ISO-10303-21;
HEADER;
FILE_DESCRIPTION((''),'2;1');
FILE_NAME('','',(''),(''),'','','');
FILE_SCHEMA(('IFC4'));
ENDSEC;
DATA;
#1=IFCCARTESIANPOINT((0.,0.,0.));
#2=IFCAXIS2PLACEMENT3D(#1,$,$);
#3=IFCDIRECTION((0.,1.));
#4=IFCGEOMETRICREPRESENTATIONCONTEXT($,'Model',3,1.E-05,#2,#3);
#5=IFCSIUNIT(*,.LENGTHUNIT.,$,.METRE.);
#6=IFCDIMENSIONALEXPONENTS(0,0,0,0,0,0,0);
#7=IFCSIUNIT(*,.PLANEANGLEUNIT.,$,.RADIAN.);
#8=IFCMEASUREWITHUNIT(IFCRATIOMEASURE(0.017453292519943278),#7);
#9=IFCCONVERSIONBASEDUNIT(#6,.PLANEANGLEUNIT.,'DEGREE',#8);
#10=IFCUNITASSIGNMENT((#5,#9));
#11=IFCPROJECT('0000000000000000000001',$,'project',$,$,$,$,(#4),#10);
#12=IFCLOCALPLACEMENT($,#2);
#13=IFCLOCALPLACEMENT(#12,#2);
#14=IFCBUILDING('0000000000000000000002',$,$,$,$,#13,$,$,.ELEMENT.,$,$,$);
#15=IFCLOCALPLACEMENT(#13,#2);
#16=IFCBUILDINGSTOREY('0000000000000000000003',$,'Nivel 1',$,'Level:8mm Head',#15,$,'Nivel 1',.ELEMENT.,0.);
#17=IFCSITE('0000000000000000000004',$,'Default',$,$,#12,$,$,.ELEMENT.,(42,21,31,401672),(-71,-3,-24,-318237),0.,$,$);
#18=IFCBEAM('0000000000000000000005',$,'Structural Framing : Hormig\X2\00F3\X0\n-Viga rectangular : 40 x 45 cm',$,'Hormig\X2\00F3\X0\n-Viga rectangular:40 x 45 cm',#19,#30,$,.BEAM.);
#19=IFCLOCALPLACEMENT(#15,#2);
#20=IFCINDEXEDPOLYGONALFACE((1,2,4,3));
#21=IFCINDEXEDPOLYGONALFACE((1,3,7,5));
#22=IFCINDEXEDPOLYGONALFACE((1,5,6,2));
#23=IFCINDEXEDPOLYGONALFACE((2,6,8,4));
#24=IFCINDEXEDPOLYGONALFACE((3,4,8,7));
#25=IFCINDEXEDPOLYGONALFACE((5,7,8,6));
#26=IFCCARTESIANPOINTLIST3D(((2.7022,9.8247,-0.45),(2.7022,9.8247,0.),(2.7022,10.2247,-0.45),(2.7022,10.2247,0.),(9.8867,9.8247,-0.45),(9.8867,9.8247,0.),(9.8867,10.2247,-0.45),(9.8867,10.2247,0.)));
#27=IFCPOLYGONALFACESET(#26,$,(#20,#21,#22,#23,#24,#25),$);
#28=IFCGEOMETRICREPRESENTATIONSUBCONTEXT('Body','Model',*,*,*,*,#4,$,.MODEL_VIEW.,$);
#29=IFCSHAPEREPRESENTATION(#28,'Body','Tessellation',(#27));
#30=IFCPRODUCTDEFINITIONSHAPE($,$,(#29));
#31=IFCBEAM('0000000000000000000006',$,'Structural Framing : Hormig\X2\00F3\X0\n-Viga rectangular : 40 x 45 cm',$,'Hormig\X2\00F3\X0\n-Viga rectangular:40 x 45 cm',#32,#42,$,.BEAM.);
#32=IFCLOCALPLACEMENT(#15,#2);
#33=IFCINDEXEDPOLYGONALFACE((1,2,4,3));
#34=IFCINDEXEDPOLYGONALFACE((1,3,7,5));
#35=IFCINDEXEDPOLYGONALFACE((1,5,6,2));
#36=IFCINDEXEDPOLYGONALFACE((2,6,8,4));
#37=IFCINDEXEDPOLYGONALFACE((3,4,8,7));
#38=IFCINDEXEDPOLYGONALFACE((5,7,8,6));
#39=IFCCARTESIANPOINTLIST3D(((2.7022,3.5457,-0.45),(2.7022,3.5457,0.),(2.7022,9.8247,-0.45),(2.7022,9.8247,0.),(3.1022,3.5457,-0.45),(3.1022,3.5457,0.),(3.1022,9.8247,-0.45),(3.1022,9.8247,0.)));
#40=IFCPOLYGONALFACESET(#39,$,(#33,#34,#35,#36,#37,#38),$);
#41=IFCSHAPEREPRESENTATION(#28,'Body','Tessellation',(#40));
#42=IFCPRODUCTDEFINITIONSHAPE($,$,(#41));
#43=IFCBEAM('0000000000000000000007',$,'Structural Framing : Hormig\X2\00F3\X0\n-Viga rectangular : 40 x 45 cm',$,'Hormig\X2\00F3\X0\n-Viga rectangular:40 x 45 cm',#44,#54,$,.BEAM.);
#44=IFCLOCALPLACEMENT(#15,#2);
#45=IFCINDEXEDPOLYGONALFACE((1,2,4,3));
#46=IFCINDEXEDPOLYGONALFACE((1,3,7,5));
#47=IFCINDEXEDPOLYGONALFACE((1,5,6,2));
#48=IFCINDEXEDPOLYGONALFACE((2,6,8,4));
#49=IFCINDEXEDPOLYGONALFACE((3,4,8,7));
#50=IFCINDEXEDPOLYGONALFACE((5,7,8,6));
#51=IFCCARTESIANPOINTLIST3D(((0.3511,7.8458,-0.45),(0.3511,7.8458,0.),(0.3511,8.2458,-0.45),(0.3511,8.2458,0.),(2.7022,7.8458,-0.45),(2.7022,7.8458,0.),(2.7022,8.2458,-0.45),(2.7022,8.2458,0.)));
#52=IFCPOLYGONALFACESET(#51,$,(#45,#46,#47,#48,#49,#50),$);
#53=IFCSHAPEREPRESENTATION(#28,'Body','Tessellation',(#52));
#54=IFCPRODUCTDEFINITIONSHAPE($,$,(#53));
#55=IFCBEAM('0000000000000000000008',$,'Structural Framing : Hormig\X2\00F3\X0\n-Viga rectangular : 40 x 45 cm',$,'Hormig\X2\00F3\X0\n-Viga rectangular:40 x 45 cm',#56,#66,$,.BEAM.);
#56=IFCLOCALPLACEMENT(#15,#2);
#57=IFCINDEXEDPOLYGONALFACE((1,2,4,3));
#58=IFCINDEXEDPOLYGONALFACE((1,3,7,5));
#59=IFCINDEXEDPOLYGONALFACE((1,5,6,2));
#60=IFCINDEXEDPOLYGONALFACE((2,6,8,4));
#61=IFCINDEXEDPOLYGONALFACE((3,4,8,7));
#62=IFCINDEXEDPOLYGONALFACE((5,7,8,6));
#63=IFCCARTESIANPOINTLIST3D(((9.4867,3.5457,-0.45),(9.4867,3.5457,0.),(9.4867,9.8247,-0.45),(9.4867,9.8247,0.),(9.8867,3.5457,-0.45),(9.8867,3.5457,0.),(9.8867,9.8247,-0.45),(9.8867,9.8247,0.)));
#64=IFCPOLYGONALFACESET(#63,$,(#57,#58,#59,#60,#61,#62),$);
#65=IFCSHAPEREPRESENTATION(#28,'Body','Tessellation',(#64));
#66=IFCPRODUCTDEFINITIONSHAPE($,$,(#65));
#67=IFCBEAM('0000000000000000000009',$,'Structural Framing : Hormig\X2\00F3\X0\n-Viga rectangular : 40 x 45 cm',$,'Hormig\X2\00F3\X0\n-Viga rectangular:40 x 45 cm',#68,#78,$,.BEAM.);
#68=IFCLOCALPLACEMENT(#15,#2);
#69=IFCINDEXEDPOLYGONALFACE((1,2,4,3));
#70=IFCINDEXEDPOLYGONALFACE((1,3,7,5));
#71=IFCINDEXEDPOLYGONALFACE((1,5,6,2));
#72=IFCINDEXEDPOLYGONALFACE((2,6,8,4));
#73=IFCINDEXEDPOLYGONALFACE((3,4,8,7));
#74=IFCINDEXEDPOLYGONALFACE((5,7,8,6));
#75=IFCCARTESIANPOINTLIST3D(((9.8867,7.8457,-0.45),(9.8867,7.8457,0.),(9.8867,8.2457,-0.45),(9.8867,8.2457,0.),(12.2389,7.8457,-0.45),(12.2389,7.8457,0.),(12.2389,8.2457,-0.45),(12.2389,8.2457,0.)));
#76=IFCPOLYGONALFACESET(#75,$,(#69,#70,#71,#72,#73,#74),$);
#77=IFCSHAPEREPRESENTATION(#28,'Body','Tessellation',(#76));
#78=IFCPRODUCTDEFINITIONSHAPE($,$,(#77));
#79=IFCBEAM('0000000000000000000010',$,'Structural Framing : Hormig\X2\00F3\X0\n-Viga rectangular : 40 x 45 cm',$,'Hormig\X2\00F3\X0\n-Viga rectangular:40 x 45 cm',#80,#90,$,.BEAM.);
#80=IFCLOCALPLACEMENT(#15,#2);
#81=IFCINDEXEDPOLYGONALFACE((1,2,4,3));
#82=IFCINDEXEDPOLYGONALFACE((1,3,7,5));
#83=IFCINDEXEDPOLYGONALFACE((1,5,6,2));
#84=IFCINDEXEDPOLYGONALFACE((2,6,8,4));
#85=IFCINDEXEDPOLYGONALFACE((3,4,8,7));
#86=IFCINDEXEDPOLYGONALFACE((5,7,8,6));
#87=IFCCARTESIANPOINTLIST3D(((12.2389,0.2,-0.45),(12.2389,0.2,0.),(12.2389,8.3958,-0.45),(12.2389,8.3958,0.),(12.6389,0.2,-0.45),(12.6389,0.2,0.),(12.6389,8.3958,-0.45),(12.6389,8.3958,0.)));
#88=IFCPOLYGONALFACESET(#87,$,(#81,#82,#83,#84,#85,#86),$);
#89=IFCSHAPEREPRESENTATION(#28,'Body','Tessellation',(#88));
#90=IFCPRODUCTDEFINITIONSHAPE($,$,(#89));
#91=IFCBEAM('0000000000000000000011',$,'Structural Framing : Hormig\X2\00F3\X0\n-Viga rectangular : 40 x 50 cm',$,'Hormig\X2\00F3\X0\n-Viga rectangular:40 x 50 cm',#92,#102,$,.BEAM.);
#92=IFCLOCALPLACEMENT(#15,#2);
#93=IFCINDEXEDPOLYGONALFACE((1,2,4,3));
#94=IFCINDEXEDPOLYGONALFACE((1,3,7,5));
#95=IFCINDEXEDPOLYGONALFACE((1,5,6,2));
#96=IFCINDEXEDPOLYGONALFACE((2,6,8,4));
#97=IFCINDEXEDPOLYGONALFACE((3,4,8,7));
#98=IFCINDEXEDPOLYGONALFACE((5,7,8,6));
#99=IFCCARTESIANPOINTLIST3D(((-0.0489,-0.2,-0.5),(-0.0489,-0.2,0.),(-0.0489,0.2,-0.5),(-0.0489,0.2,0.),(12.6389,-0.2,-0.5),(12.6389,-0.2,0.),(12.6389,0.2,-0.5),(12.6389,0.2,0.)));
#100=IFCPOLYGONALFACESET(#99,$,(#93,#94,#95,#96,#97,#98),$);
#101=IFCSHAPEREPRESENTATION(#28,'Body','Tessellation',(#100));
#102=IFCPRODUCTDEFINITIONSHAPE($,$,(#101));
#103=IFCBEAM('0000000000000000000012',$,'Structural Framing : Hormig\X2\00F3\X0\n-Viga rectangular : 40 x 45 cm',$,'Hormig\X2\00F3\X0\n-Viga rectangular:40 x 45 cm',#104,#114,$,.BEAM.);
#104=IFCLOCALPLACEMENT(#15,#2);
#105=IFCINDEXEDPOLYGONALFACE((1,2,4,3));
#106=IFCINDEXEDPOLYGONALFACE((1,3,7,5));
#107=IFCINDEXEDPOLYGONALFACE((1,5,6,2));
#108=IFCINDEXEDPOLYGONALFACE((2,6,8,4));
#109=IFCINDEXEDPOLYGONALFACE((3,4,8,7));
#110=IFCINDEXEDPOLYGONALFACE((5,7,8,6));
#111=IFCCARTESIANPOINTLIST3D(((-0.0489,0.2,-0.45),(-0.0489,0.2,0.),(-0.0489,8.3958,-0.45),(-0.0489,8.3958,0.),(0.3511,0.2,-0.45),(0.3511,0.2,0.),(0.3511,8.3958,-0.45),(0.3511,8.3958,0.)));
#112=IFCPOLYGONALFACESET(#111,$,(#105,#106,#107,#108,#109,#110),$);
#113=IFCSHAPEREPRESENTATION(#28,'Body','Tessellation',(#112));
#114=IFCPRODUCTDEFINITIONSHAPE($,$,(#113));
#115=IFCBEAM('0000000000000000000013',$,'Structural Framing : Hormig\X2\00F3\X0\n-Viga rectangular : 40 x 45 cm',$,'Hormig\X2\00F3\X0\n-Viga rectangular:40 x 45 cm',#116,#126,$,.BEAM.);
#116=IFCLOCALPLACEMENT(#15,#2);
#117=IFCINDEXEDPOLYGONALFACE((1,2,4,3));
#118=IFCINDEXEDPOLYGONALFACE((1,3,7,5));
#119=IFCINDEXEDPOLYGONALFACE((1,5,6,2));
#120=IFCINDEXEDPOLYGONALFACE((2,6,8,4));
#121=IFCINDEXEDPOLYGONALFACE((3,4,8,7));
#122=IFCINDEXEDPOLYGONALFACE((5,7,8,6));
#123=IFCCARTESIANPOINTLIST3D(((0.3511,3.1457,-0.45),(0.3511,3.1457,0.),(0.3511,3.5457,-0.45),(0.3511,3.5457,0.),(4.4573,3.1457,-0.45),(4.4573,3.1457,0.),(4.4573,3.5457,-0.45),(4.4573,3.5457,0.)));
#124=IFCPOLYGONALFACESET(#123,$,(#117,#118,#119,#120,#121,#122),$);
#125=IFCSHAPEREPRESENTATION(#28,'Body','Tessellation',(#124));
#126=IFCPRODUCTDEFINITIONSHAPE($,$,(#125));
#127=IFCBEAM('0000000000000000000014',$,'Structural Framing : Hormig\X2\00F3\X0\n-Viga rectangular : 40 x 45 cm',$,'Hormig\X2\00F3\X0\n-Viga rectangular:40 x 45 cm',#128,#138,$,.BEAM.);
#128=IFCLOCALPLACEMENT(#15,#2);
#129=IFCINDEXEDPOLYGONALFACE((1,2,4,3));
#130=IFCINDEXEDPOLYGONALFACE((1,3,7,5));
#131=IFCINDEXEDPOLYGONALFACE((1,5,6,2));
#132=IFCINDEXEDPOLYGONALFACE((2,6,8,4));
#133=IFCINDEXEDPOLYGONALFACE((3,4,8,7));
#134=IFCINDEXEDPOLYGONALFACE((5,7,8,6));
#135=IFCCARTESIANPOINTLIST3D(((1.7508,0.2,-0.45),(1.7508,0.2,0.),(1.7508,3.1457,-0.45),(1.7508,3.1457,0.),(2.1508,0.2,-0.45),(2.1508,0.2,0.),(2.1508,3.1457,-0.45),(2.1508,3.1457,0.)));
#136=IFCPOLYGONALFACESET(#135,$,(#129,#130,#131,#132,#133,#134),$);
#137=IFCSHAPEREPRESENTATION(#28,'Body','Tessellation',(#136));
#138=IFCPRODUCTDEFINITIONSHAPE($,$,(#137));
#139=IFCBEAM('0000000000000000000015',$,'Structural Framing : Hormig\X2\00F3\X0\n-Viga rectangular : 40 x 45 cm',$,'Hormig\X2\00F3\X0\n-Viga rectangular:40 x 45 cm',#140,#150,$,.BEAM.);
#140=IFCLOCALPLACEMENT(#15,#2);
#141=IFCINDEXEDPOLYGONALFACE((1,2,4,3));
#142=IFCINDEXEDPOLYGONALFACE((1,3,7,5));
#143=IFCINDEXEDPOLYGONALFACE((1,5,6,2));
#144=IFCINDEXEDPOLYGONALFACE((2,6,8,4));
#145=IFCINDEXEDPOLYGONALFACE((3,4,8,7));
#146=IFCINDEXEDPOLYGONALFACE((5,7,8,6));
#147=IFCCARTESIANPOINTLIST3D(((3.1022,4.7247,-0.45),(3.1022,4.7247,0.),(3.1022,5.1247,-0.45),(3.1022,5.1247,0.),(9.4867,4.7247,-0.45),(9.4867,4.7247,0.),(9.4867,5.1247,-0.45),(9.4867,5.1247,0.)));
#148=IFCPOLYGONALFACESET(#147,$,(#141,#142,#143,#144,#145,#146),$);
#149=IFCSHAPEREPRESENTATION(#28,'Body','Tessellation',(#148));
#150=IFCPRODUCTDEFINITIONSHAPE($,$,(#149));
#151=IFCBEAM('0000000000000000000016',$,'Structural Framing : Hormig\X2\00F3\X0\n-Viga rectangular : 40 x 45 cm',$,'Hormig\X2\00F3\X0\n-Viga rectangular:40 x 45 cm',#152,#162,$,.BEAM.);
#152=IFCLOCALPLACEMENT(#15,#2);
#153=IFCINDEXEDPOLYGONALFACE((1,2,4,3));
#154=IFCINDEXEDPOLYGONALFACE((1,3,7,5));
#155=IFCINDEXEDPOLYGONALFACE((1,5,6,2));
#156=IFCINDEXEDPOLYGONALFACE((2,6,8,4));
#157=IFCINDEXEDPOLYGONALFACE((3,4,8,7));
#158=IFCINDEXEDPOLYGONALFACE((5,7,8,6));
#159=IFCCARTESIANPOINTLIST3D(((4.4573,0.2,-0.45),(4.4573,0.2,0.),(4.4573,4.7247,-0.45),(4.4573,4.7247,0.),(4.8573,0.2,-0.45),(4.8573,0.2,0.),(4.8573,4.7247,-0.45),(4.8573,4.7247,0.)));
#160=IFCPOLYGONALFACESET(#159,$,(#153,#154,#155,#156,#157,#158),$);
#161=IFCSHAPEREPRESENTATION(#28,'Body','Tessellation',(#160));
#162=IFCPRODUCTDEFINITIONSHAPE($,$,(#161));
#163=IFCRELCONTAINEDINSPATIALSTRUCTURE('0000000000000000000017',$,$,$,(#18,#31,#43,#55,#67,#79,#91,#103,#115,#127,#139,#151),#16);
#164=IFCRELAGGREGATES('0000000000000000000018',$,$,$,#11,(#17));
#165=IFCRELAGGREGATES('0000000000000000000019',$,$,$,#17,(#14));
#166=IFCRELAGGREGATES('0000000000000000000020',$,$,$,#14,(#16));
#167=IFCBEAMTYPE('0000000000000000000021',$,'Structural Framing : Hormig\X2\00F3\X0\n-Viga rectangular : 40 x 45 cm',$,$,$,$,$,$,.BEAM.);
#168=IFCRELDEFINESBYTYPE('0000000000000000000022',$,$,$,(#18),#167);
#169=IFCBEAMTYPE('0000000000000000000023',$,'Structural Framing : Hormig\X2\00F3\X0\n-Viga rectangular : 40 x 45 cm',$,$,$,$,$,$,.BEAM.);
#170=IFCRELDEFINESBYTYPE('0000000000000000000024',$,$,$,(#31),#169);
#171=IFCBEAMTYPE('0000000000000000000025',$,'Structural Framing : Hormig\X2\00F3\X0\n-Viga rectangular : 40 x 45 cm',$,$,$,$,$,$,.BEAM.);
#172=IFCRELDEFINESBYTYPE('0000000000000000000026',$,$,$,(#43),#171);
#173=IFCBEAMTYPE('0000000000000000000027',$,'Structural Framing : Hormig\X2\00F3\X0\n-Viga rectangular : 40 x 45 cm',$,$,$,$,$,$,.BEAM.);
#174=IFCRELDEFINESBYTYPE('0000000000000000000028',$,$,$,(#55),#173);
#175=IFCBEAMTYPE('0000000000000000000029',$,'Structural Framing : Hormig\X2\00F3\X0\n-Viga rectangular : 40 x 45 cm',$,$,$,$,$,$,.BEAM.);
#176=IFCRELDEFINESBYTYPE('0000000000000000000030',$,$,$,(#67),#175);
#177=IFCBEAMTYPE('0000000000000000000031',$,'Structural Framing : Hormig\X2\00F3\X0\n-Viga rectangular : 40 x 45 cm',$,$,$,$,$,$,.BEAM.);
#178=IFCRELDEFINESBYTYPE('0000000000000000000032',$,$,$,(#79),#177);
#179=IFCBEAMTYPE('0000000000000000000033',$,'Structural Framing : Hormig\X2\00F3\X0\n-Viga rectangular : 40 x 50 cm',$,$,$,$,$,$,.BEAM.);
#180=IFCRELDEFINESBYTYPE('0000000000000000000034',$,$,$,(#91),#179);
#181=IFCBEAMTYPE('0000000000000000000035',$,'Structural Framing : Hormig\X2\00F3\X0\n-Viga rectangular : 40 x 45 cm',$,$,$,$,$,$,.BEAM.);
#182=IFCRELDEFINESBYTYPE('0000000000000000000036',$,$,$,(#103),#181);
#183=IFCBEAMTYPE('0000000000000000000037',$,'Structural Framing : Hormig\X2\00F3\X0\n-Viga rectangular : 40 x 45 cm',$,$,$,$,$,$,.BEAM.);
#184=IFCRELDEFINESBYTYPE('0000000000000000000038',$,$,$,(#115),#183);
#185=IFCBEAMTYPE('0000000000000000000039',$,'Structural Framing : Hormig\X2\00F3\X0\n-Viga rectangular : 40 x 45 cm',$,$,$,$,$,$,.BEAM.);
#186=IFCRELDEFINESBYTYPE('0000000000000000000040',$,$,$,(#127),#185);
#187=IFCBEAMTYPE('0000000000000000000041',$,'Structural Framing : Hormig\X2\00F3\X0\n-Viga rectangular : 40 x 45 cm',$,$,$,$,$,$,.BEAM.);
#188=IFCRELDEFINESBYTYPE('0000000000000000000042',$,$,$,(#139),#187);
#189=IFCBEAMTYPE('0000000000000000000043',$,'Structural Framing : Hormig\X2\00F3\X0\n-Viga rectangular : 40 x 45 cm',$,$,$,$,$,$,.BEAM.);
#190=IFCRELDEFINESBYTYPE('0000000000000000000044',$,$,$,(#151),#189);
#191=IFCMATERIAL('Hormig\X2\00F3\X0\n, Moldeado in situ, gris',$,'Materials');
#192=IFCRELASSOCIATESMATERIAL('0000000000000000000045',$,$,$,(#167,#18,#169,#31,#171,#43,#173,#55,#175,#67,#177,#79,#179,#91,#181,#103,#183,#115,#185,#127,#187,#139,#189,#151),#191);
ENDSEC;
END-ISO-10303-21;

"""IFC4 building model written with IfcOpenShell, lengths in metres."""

from ifc_helpers import new_model, entity, si_unit, converted_unit, direction, frame, origin, place, context, subcontext, project, spatial, indexed_curve, outline, extrude, source, transform, mapped, material, type_object, type_shapes, element, save


model = new_model("IFC4")

# Units and contexts
model_context = context("Model", 3, precision=1e-05, world=origin(), true_north=direction((0.0, 1.0)))
body_context = subcontext(model_context, "Body", "Model", "MODEL_VIEW")
ifc_project = project(units=[si_unit("LENGTHUNIT", "METRE"), converted_unit("PLANEANGLEUNIT", "DEGREE", entity("IfcRatioMeasure", 0.017453292519943278), si_unit("PLANEANGLEUNIT", "RADIAN"), dimensions=[0, 0, 0, 0, 0, 0, 0])], contexts=[model_context])

# Site, building, storey
site_placement = place(None, origin())
site = spatial("IfcSite", under=ifc_project, at=site_placement, Name="Default", CompositionType="ELEMENT", RefLatitude=(42, 21, 31, 401672), RefLongitude=(-71, -3, -24, -318237), RefElevation=0.0)
building_placement = place(site_placement, origin())
building = spatial("IfcBuilding", under=site, at=building_placement, CompositionType="ELEMENT")
storey_placement = place(building_placement, origin())
storey = spatial("IfcBuildingStorey", under=building, at=storey_placement, Name="Nivel 1", ObjectType="Level:8mm Head", LongName="Nivel 1", CompositionType="ELEMENT", Elevation=0.0)

# Beams
ifc_material_1 = material(Name="Hormigón, Moldeado in situ, gris", Category="Materials")
beam_type_1 = type_object("IfcBeamType", Name="Structural Framing : Hormigón-Viga rectangular : 40 x 45 cm", PredefinedType="BEAM", material=ifc_material_1)
shared_shape_1 = source(origin(), body_context, "Body", "SweptSolid", [
    extrude(outline(indexed_curve([(-0.225, -0.2), (0.225, -0.2), (0.225, 0.2), (-0.225, 0.2), (-0.225, -0.2)], self_intersect=False)), frame((2.7022, 10.0247, -0.225), z_axis=(1.0, 0.0, 0.0), x_axis=(0.0, 0.0, -1.0)), (0.0, 0.0, 1.0), 7.1845),
])
type_shapes(beam_type_1, [shared_shape_1])
beam_1_placement = place(storey_placement, origin())
element("IfcBeam", 1, at=beam_1_placement, inside=storey, type_object=beam_type_1, material=ifc_material_1, Name="Structural Framing : Hormigón-Viga rectangular : 40 x 45 cm", ObjectType="Hormigón-Viga rectangular:40 x 45 cm", PredefinedType="BEAM", context=body_context, shape_type="MappedRepresentation", body=[
    mapped(shared_shape_1, transform((0.0, 0.0, 0.0), scale=1.0)),
])
beam_type_2 = type_object("IfcBeamType", Name="Structural Framing : Hormigón-Viga rectangular : 40 x 45 cm", PredefinedType="BEAM", material=ifc_material_1)
shared_shape_2 = source(origin(), body_context, "Body", "SweptSolid", [
    extrude(outline(indexed_curve([(-0.2, -0.225), (0.2, -0.225), (0.2, 0.225), (-0.2, 0.225), (-0.2, -0.225)], self_intersect=False)), frame((2.9022, 3.5457, -0.225), z_axis=(0.0, 1.0, 0.0), x_axis=(-1.0, 0.0, 0.0)), (0.0, 0.0, 1.0), 6.279),
])
type_shapes(beam_type_2, [shared_shape_2])
beam_2_placement = place(storey_placement, origin())
element("IfcBeam", 2, at=beam_2_placement, inside=storey, type_object=beam_type_2, material=ifc_material_1, Name="Structural Framing : Hormigón-Viga rectangular : 40 x 45 cm", ObjectType="Hormigón-Viga rectangular:40 x 45 cm", PredefinedType="BEAM", context=body_context, shape_type="MappedRepresentation", body=[
    mapped(shared_shape_2, transform((0.0, 0.0, 0.0), scale=1.0)),
])
beam_type_3 = type_object("IfcBeamType", Name="Structural Framing : Hormigón-Viga rectangular : 40 x 45 cm", PredefinedType="BEAM", material=ifc_material_1)
shared_shape_3 = source(origin(), body_context, "Body", "SweptSolid", [
    extrude(outline(indexed_curve([(-0.225, -0.2), (0.225, -0.2), (0.225, 0.2), (-0.225, 0.2), (-0.225, -0.2)], self_intersect=False)), frame((0.3511, 8.0458, -0.225), z_axis=(1.0, 0.0, 0.0), x_axis=(0.0, 0.0, -1.0)), (0.0, 0.0, 1.0), 2.351),
])
type_shapes(beam_type_3, [shared_shape_3])
beam_3_placement = place(storey_placement, origin())
element("IfcBeam", 3, at=beam_3_placement, inside=storey, type_object=beam_type_3, material=ifc_material_1, Name="Structural Framing : Hormigón-Viga rectangular : 40 x 45 cm", ObjectType="Hormigón-Viga rectangular:40 x 45 cm", PredefinedType="BEAM", context=body_context, shape_type="MappedRepresentation", body=[
    mapped(shared_shape_3, transform((0.0, 0.0, 0.0), scale=1.0)),
])
beam_type_4 = type_object("IfcBeamType", Name="Structural Framing : Hormigón-Viga rectangular : 40 x 45 cm", PredefinedType="BEAM", material=ifc_material_1)
shared_shape_4 = source(origin(), body_context, "Body", "SweptSolid", [
    extrude(outline(indexed_curve([(-0.2, -0.225), (0.2, -0.225), (0.2, 0.225), (-0.2, 0.225), (-0.2, -0.225)], self_intersect=False)), frame((9.6867, 9.8247, -0.225), z_axis=(0.0, -1.0, 0.0), x_axis=(-1.0, 0.0, 0.0)), (0.0, 0.0, 1.0), 6.279),
])
type_shapes(beam_type_4, [shared_shape_4])
beam_4_placement = place(storey_placement, origin())
element("IfcBeam", 4, at=beam_4_placement, inside=storey, type_object=beam_type_4, material=ifc_material_1, Name="Structural Framing : Hormigón-Viga rectangular : 40 x 45 cm", ObjectType="Hormigón-Viga rectangular:40 x 45 cm", PredefinedType="BEAM", context=body_context, shape_type="MappedRepresentation", body=[
    mapped(shared_shape_4, transform((0.0, 0.0, 0.0), scale=1.0)),
])
beam_type_5 = type_object("IfcBeamType", Name="Structural Framing : Hormigón-Viga rectangular : 40 x 45 cm", PredefinedType="BEAM", material=ifc_material_1)
shared_shape_5 = source(origin(), body_context, "Body", "SweptSolid", [
    extrude(outline(indexed_curve([(-0.225, -0.2), (0.225, -0.2), (0.225, 0.2), (-0.225, 0.2), (-0.225, -0.2)], self_intersect=False)), frame((9.8867, 8.0457, -0.225), z_axis=(1.0, 0.0, 0.0), x_axis=(0.0, 0.0, -1.0)), (0.0, 0.0, 1.0), 2.3522),
])
type_shapes(beam_type_5, [shared_shape_5])
beam_5_placement = place(storey_placement, origin())
element("IfcBeam", 5, at=beam_5_placement, inside=storey, type_object=beam_type_5, material=ifc_material_1, Name="Structural Framing : Hormigón-Viga rectangular : 40 x 45 cm", ObjectType="Hormigón-Viga rectangular:40 x 45 cm", PredefinedType="BEAM", context=body_context, shape_type="MappedRepresentation", body=[
    mapped(shared_shape_5, transform((0.0, 0.0, 0.0), scale=1.0)),
])
beam_type_6 = type_object("IfcBeamType", Name="Structural Framing : Hormigón-Viga rectangular : 40 x 45 cm", PredefinedType="BEAM", material=ifc_material_1)
shared_shape_6 = source(origin(), body_context, "Body", "SweptSolid", [
    extrude(outline(indexed_curve([(-0.2, -0.225), (0.2, -0.225), (0.2, 0.225), (-0.2, 0.225), (-0.2, -0.225)], self_intersect=False)), frame((12.4389, 8.3958, -0.225), z_axis=(0.0, -1.0, 0.0), x_axis=(-1.0, 0.0, 0.0)), (0.0, 0.0, 1.0), 8.1958),
])
type_shapes(beam_type_6, [shared_shape_6])
beam_6_placement = place(storey_placement, origin())
element("IfcBeam", 6, at=beam_6_placement, inside=storey, type_object=beam_type_6, material=ifc_material_1, Name="Structural Framing : Hormigón-Viga rectangular : 40 x 45 cm", ObjectType="Hormigón-Viga rectangular:40 x 45 cm", PredefinedType="BEAM", context=body_context, shape_type="MappedRepresentation", body=[
    mapped(shared_shape_6, transform((0.0, 0.0, 0.0), scale=1.0)),
])
beam_type_7 = type_object("IfcBeamType", Name="Structural Framing : Hormigón-Viga rectangular : 40 x 50 cm", PredefinedType="BEAM", material=ifc_material_1)
shared_shape_7 = source(origin(), body_context, "Body", "SweptSolid", [
    extrude(outline(indexed_curve([(-0.25, -0.2), (0.25, -0.2), (0.25, 0.2), (-0.25, 0.2), (-0.25, -0.2)], self_intersect=False)), frame((12.6389, 0.0, -0.25), z_axis=(-1.0, 0.0, 0.0), x_axis=(0.0, 0.0, -1.0)), (0.0, 0.0, 1.0), 12.6878),
])
type_shapes(beam_type_7, [shared_shape_7])
beam_7_placement = place(storey_placement, origin())
element("IfcBeam", 7, at=beam_7_placement, inside=storey, type_object=beam_type_7, material=ifc_material_1, Name="Structural Framing : Hormigón-Viga rectangular : 40 x 50 cm", ObjectType="Hormigón-Viga rectangular:40 x 50 cm", PredefinedType="BEAM", context=body_context, shape_type="MappedRepresentation", body=[
    mapped(shared_shape_7, transform((0.0, 0.0, 0.0), scale=1.0)),
])
beam_type_8 = type_object("IfcBeamType", Name="Structural Framing : Hormigón-Viga rectangular : 40 x 45 cm", PredefinedType="BEAM", material=ifc_material_1)
shared_shape_8 = source(origin(), body_context, "Body", "SweptSolid", [
    extrude(outline(indexed_curve([(-0.2, -0.225), (0.2, -0.225), (0.2, 0.225), (-0.2, 0.225), (-0.2, -0.225)], self_intersect=False)), frame((0.1511, 0.2, -0.225), z_axis=(0.0, 1.0, 0.0), x_axis=(-1.0, 0.0, 0.0)), (0.0, 0.0, 1.0), 8.1958),
])
type_shapes(beam_type_8, [shared_shape_8])
beam_8_placement = place(storey_placement, origin())
element("IfcBeam", 8, at=beam_8_placement, inside=storey, type_object=beam_type_8, material=ifc_material_1, Name="Structural Framing : Hormigón-Viga rectangular : 40 x 45 cm", ObjectType="Hormigón-Viga rectangular:40 x 45 cm", PredefinedType="BEAM", context=body_context, shape_type="MappedRepresentation", body=[
    mapped(shared_shape_8, transform((0.0, 0.0, 0.0), scale=1.0)),
])
beam_type_9 = type_object("IfcBeamType", Name="Structural Framing : Hormigón-Viga rectangular : 40 x 45 cm", PredefinedType="BEAM", material=ifc_material_1)
shared_shape_9 = source(origin(), body_context, "Body", "SweptSolid", [
    extrude(outline(indexed_curve([(-0.225, -0.2), (0.225, -0.2), (0.225, 0.2), (-0.225, 0.2), (-0.225, -0.2)], self_intersect=False)), frame((0.3511, 3.3457, -0.225), z_axis=(1.0, 0.0, 0.0), x_axis=(0.0, 0.0, -1.0)), (0.0, 0.0, 1.0), 4.1062),
])
type_shapes(beam_type_9, [shared_shape_9])
beam_9_placement = place(storey_placement, origin())
element("IfcBeam", 9, at=beam_9_placement, inside=storey, type_object=beam_type_9, material=ifc_material_1, Name="Structural Framing : Hormigón-Viga rectangular : 40 x 45 cm", ObjectType="Hormigón-Viga rectangular:40 x 45 cm", PredefinedType="BEAM", context=body_context, shape_type="MappedRepresentation", body=[
    mapped(shared_shape_9, transform((0.0, 0.0, 0.0), scale=1.0)),
])
beam_type_10 = type_object("IfcBeamType", Name="Structural Framing : Hormigón-Viga rectangular : 40 x 45 cm", PredefinedType="BEAM", material=ifc_material_1)
shared_shape_10 = source(origin(), body_context, "Body", "SweptSolid", [
    extrude(outline(indexed_curve([(-0.2, -0.225), (0.2, -0.225), (0.2, 0.225), (-0.2, 0.225), (-0.2, -0.225)], self_intersect=False)), frame((1.9508, 3.1457, -0.225), z_axis=(0.0, -1.0, 0.0), x_axis=(-1.0, 0.0, 0.0)), (0.0, 0.0, 1.0), 2.9457),
])
type_shapes(beam_type_10, [shared_shape_10])
beam_10_placement = place(storey_placement, origin())
element("IfcBeam", 10, at=beam_10_placement, inside=storey, type_object=beam_type_10, material=ifc_material_1, Name="Structural Framing : Hormigón-Viga rectangular : 40 x 45 cm", ObjectType="Hormigón-Viga rectangular:40 x 45 cm", PredefinedType="BEAM", context=body_context, shape_type="MappedRepresentation", body=[
    mapped(shared_shape_10, transform((0.0, 0.0, 0.0), scale=1.0)),
])
beam_type_11 = type_object("IfcBeamType", Name="Structural Framing : Hormigón-Viga rectangular : 40 x 45 cm", PredefinedType="BEAM", material=ifc_material_1)
shared_shape_11 = source(origin(), body_context, "Body", "SweptSolid", [
    extrude(outline(indexed_curve([(-0.225, -0.2), (0.225, -0.2), (0.225, 0.2), (-0.225, 0.2), (-0.225, -0.2)], self_intersect=False)), frame((3.1022, 4.9247, -0.225), z_axis=(1.0, 0.0, 0.0), x_axis=(0.0, 0.0, -1.0)), (0.0, 0.0, 1.0), 6.3845),
])
type_shapes(beam_type_11, [shared_shape_11])
beam_11_placement = place(storey_placement, origin())
element("IfcBeam", 11, at=beam_11_placement, inside=storey, type_object=beam_type_11, material=ifc_material_1, Name="Structural Framing : Hormigón-Viga rectangular : 40 x 45 cm", ObjectType="Hormigón-Viga rectangular:40 x 45 cm", PredefinedType="BEAM", context=body_context, shape_type="MappedRepresentation", body=[
    mapped(shared_shape_11, transform((0.0, 0.0, 0.0), scale=1.0)),
])
beam_type_12 = type_object("IfcBeamType", Name="Structural Framing : Hormigón-Viga rectangular : 40 x 45 cm", PredefinedType="BEAM", material=ifc_material_1)
shared_shape_12 = source(origin(), body_context, "Body", "SweptSolid", [
    extrude(outline(indexed_curve([(-0.2, -0.225), (0.2, -0.225), (0.2, 0.225), (-0.2, 0.225), (-0.2, -0.225)], self_intersect=False)), frame((4.6573, 4.7247, -0.225), z_axis=(0.0, -1.0, 0.0), x_axis=(-1.0, 0.0, 0.0)), (0.0, 0.0, 1.0), 4.5247),
])
type_shapes(beam_type_12, [shared_shape_12])
beam_12_placement = place(storey_placement, origin())
element("IfcBeam", 12, at=beam_12_placement, inside=storey, type_object=beam_type_12, material=ifc_material_1, Name="Structural Framing : Hormigón-Viga rectangular : 40 x 45 cm", ObjectType="Hormigón-Viga rectangular:40 x 45 cm", PredefinedType="BEAM", context=body_context, shape_type="MappedRepresentation", body=[
    mapped(shared_shape_12, transform((0.0, 0.0, 0.0), scale=1.0)),
])

save(model, "model.ifc")
